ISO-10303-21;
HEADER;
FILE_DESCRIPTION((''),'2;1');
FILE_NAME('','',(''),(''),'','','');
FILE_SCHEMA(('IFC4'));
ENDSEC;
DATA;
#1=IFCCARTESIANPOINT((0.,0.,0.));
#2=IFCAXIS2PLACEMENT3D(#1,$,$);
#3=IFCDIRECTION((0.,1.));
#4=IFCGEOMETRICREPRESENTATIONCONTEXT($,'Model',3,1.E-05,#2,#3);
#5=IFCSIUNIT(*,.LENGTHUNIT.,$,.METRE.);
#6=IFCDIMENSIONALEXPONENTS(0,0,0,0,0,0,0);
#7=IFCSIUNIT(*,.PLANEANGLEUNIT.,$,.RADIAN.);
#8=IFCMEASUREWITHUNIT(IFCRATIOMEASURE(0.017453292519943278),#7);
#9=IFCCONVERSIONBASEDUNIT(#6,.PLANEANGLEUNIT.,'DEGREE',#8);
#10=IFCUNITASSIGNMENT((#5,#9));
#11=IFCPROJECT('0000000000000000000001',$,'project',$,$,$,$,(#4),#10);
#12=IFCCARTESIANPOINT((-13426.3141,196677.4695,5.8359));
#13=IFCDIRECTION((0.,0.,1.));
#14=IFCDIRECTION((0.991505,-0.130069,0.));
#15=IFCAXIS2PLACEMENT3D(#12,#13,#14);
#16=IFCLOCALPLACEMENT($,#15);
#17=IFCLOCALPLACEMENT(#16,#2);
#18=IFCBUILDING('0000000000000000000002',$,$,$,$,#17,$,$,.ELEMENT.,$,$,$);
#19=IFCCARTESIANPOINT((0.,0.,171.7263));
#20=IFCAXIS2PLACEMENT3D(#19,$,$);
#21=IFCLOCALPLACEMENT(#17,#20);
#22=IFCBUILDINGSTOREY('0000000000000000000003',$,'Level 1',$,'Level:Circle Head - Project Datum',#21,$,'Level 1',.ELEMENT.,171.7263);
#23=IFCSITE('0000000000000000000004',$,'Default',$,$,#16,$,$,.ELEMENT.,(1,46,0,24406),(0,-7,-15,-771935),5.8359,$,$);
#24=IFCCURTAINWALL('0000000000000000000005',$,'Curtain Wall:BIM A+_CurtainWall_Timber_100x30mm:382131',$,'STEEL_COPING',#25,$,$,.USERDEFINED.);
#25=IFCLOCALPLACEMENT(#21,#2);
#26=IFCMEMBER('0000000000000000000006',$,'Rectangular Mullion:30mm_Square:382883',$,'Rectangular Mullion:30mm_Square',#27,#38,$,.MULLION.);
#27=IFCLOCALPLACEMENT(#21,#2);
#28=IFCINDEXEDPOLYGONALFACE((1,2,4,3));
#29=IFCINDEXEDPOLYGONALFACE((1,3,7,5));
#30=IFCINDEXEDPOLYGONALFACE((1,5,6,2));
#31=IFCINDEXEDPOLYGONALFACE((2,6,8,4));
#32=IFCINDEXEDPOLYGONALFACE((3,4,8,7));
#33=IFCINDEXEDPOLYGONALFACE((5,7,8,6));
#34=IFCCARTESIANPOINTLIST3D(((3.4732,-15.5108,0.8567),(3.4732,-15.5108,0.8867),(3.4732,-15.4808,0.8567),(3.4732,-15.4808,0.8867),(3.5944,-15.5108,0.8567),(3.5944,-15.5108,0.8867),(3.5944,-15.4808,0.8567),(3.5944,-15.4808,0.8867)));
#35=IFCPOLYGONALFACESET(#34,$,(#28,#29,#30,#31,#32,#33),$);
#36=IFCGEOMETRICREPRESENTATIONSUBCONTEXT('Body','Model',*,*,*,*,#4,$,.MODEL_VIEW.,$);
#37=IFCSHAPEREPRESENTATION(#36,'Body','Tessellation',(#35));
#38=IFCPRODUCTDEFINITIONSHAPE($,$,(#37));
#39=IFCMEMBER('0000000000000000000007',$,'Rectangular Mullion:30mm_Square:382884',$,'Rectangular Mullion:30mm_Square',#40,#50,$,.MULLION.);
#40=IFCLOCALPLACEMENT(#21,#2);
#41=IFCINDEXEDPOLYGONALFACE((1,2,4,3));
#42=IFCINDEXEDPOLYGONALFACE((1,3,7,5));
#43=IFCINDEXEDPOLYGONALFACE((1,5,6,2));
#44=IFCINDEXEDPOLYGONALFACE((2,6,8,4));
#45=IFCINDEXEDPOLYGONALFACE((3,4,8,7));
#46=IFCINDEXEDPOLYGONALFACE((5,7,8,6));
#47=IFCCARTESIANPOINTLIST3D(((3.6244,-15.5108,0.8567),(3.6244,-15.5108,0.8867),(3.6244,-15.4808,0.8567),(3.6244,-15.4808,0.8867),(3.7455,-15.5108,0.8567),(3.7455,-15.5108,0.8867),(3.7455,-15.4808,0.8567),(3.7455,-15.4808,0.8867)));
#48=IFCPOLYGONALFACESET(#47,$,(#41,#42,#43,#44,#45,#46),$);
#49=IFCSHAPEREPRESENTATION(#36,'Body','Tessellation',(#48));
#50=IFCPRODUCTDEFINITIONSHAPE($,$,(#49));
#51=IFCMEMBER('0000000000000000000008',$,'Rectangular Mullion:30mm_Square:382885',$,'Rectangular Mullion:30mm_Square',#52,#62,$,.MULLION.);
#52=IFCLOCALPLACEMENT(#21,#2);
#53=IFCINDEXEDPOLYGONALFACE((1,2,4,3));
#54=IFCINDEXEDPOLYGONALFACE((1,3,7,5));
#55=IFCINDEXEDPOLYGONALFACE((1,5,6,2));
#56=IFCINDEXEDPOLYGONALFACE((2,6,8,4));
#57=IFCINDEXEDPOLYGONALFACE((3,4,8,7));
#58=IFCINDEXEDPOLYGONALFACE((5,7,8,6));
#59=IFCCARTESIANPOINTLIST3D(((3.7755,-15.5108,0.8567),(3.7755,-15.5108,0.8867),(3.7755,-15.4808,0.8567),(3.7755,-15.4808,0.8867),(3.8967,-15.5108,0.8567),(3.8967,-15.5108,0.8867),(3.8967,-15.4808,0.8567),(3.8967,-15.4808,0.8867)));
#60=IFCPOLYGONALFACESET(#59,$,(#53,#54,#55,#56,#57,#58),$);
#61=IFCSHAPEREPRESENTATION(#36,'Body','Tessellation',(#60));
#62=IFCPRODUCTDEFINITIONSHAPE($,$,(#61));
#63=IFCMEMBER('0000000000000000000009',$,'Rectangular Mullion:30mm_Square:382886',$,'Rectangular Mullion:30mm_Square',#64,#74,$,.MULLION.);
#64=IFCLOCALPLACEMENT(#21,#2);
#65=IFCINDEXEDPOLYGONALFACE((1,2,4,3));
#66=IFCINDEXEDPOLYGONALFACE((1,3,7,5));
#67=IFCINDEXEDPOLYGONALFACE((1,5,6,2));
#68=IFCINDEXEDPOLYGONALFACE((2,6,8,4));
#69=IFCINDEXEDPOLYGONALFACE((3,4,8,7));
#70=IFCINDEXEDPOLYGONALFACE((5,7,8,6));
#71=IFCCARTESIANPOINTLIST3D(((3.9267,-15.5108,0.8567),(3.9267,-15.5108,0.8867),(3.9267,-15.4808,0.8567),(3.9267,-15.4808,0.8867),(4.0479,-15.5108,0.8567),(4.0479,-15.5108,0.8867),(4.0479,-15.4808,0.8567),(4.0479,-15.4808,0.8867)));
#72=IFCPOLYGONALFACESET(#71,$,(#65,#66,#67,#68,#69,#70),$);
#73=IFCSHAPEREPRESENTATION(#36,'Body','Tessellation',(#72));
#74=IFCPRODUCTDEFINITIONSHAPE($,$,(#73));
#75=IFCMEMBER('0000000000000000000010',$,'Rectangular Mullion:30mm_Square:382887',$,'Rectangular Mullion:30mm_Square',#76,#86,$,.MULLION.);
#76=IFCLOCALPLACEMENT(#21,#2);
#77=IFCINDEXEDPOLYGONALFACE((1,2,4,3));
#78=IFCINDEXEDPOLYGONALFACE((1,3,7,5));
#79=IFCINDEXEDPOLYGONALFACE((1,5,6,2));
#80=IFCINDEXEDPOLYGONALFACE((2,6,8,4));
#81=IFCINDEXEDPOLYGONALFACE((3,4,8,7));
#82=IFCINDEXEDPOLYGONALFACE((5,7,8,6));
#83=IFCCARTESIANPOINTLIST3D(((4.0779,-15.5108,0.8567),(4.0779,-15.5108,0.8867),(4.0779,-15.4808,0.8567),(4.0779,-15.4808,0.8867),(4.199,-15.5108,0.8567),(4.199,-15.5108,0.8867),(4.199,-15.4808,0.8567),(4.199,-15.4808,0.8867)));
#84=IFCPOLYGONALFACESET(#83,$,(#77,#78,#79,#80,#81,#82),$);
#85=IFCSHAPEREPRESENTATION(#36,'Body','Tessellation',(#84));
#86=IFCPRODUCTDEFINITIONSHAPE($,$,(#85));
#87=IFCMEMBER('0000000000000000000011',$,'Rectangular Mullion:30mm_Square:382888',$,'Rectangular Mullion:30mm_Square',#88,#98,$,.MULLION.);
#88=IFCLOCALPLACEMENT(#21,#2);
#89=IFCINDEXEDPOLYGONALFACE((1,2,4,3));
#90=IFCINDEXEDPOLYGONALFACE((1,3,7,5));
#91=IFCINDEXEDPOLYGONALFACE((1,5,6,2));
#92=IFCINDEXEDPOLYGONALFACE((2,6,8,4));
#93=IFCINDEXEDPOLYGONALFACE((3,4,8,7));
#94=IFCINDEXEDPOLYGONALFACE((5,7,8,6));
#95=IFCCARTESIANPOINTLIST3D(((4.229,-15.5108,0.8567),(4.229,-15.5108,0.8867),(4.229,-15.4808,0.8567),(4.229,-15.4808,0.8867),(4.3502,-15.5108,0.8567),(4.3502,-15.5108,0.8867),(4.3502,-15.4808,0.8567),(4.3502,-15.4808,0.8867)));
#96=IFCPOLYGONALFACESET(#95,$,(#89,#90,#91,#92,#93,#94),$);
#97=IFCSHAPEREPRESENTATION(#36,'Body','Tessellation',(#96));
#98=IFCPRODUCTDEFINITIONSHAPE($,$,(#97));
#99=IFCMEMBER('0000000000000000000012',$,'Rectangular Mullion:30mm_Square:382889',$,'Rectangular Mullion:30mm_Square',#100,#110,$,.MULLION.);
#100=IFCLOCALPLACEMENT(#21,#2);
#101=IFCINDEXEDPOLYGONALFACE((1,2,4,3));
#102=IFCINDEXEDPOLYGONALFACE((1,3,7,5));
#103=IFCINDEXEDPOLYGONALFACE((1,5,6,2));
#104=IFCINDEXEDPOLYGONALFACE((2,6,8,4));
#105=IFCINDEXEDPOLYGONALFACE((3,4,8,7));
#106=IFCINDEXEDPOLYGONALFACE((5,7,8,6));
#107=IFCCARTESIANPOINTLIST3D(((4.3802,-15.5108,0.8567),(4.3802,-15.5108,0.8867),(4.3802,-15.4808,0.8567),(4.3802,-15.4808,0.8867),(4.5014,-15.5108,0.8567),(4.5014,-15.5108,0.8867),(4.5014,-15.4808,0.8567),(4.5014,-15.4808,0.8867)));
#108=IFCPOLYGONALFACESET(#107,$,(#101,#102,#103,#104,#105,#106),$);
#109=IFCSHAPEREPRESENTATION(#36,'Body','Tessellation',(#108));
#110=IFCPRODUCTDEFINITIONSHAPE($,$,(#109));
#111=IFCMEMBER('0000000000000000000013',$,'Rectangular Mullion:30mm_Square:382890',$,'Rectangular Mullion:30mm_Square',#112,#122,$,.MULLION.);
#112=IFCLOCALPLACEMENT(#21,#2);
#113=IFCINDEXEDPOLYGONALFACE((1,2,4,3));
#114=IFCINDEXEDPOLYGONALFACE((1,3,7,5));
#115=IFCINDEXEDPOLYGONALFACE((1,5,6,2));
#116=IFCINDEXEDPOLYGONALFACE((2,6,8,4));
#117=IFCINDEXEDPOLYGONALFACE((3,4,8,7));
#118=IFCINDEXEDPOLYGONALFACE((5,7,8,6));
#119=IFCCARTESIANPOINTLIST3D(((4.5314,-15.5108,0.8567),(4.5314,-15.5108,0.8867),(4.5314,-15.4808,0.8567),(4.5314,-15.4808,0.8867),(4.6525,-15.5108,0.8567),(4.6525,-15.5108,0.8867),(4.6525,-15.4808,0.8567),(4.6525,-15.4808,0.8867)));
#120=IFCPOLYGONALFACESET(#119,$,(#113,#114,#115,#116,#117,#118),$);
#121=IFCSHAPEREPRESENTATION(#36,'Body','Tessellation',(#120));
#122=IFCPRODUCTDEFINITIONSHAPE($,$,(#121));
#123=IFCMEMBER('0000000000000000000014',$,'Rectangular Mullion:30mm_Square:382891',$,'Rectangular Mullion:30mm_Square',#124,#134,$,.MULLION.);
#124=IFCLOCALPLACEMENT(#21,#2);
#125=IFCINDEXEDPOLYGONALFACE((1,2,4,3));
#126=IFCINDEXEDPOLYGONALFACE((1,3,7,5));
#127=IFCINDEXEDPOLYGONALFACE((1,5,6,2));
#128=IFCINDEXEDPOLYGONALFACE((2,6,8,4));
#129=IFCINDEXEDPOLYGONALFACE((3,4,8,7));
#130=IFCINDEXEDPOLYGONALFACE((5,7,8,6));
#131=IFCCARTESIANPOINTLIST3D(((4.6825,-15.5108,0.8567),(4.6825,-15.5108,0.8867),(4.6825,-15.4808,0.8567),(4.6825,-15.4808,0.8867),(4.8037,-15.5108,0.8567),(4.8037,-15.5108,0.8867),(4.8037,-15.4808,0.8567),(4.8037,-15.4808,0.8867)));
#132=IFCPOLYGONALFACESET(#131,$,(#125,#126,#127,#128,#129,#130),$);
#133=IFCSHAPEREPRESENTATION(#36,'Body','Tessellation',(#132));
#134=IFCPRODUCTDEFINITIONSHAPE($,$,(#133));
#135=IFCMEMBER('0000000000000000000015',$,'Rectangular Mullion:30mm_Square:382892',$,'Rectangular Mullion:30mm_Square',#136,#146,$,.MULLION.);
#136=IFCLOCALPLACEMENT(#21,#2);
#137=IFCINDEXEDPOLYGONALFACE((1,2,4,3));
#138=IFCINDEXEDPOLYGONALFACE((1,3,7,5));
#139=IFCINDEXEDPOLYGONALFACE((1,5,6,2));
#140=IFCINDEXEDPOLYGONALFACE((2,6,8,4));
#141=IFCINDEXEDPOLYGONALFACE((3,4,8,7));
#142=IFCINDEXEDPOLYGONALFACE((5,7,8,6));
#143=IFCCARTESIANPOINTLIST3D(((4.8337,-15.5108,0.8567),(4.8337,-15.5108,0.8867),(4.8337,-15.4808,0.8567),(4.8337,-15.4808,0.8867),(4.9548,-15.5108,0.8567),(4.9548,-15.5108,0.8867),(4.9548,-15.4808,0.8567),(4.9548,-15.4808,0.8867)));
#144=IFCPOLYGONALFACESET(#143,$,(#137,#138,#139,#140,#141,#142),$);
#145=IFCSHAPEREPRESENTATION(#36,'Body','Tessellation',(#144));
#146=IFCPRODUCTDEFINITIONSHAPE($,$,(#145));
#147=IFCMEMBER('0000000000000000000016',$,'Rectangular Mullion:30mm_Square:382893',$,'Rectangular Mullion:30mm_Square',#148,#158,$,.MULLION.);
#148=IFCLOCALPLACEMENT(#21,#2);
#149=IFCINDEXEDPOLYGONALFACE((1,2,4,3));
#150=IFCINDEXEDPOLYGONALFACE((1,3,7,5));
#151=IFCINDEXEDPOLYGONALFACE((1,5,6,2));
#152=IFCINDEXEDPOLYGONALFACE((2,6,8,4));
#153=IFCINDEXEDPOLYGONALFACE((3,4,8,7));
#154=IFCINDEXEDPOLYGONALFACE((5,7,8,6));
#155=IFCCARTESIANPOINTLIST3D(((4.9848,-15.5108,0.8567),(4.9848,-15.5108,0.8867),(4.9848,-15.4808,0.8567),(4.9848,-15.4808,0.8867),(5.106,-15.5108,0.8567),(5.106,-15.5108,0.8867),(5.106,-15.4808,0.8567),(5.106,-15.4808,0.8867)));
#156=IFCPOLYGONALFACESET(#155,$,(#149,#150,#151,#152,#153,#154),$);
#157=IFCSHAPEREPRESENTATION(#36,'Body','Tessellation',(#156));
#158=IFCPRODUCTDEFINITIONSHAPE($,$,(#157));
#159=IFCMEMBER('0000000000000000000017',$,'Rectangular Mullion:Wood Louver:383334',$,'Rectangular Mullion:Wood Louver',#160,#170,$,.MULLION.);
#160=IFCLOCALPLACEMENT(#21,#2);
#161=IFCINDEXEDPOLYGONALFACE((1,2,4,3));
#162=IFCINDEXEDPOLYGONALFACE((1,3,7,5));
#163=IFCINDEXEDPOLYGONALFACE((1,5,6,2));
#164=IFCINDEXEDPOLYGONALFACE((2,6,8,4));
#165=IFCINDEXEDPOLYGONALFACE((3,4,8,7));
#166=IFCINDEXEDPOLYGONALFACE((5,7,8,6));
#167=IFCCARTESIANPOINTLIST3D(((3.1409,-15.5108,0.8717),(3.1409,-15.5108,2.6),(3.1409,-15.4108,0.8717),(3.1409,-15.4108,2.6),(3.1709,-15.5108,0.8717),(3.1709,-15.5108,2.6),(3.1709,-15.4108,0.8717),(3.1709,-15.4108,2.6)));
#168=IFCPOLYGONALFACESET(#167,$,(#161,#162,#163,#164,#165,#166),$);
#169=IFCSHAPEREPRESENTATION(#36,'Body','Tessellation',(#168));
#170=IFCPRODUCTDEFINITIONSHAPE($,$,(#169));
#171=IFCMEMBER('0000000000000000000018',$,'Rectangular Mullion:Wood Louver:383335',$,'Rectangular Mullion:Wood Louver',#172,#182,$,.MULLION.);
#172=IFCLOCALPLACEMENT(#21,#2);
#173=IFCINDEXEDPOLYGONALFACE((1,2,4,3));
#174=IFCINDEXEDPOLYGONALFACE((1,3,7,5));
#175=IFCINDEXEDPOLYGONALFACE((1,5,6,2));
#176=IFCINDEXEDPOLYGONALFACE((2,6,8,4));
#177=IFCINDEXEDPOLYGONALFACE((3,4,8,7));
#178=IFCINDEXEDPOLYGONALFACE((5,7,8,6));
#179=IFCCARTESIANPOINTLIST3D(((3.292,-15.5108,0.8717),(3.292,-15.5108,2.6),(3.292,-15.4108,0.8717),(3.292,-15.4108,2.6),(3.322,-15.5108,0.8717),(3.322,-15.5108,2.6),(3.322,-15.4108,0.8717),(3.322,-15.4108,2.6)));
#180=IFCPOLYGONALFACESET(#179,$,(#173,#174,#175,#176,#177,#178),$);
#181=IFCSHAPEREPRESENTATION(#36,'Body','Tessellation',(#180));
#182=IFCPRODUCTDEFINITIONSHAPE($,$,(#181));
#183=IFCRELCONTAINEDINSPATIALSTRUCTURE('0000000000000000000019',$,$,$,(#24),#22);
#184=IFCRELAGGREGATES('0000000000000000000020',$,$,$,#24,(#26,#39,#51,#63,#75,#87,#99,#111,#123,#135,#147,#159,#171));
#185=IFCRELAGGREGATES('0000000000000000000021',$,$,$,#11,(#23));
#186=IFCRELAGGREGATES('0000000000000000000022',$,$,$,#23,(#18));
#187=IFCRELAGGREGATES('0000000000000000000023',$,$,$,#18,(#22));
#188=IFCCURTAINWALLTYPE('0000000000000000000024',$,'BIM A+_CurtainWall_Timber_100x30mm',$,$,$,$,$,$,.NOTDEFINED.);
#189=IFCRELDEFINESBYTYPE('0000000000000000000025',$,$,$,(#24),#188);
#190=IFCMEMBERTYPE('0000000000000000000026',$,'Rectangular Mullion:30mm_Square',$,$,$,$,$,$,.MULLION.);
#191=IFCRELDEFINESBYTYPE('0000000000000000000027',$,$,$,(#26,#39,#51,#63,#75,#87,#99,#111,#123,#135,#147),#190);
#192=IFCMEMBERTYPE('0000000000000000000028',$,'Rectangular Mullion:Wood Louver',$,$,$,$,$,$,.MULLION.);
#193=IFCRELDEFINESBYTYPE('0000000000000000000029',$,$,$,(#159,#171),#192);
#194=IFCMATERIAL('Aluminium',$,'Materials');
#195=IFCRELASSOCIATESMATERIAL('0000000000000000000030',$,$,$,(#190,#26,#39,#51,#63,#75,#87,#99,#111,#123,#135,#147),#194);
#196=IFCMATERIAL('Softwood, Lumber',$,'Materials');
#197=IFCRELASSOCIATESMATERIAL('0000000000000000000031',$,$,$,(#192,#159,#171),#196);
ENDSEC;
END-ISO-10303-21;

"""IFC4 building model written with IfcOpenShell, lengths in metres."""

from ifc_helpers import new_model, entity, si_unit, converted_unit, direction, frame, origin, place, context, subcontext, project, spatial, indexed_curve, outline, extrude, source, transform, mapped, material, type_object, type_shapes, element, aggregate, save


model = new_model("IFC4")

# Units and contexts
model_context = context("Model", 3, precision=1e-05, world=origin(), true_north=direction((0.0, 1.0)))
body_context = subcontext(model_context, "Body", "Model", "MODEL_VIEW")
ifc_project = project(units=[si_unit("LENGTHUNIT", "METRE"), converted_unit("PLANEANGLEUNIT", "DEGREE", entity("IfcRatioMeasure", 0.017453292519943278), si_unit("PLANEANGLEUNIT", "RADIAN"), dimensions=[0, 0, 0, 0, 0, 0, 0])], contexts=[model_context])

# Site, building, storey
site_placement = place(None, frame((-13426.3141, 196677.4695, 5.8359), z_axis=(0.0, 0.0, 1.0), x_axis=(0.991505, -0.130069, 0.0)))
site = spatial("IfcSite", under=ifc_project, at=site_placement, Name="Default", CompositionType="ELEMENT", RefLatitude=(1, 46, 0, 24406), RefLongitude=(0, -7, -15, -771935), RefElevation=5.8359)
building_placement = place(site_placement, origin())
building = spatial("IfcBuilding", under=site, at=building_placement, CompositionType="ELEMENT")
storey_placement = place(building_placement, frame((0.0, 0.0, 171.7263)))
storey = spatial("IfcBuildingStorey", under=building, at=storey_placement, Name="Level 1", ObjectType="Level:Circle Head - Project Datum", LongName="Level 1", CompositionType="ELEMENT", Elevation=171.7263)

# Curtain wall, members
ifc_material_1 = material(Name="Aluminium", Category="Materials")
curtain_wall_type_1 = type_object("IfcCurtainWallType", Name="BIM A+_CurtainWall_Timber_100x30mm", PredefinedType="NOTDEFINED")
curtain_wall_1_placement = place(storey_placement, frame((0.0, 0.0, -171.7263)))
curtain_wall_1 = element("IfcCurtainWall", 1, at=curtain_wall_1_placement, inside=storey, type_object=curtain_wall_type_1, Name="Curtain Wall:BIM A+_CurtainWall_Timber_100x30mm:382131", ObjectType="STEEL_COPING", PredefinedType="USERDEFINED")
member_type_1 = type_object("IfcMemberType", Name="Rectangular Mullion:30mm_Square", PredefinedType="MULLION", material=ifc_material_1)
shared_shape_1 = source(origin(), body_context, "Body", "SweptSolid", [
    extrude(outline(indexed_curve([(-0.015, -0.015), (0.015, -0.015), (0.015, 0.015), (-0.015, 0.015), (-0.015, -0.015)], self_intersect=False)), frame((0.0, 0.0, -0.1212), z_axis=(0.0, 0.0, 1.0), x_axis=(0.0, -1.0, 0.0)), (0.0, 0.0, 1.0), 0.1212),
])
type_shapes(member_type_1, [shared_shape_1])
member_1_placement = place(curtain_wall_1_placement, frame((3.5944, -15.4958, 172.598), z_axis=(1.0, 0.0, 0.0), x_axis=(0.0, 0.0, 1.0)))
member_1 = element("IfcMember", 2, at=member_1_placement, type_object=member_type_1, material=ifc_material_1, Name="Rectangular Mullion:30mm_Square:382883", ObjectType="Rectangular Mullion:30mm_Square", PredefinedType="MULLION", context=body_context, shape_type="MappedRepresentation", body=[
    mapped(shared_shape_1, transform((0.0, 0.0, 0.0), scale=1.0)),
])
member_2_placement = place(curtain_wall_1_placement, frame((3.7455, -15.4958, 172.598), z_axis=(1.0, 0.0, 0.0), x_axis=(0.0, 0.0, 1.0)))
member_2 = element("IfcMember", 3, at=member_2_placement, type_object=member_type_1, material=ifc_material_1, Name="Rectangular Mullion:30mm_Square:382884", ObjectType="Rectangular Mullion:30mm_Square", PredefinedType="MULLION", context=body_context, shape_type="MappedRepresentation", body=[
    mapped(shared_shape_1, transform((0.0, 0.0, 0.0), scale=1.0)),
])
member_3_placement = place(curtain_wall_1_placement, frame((3.8967, -15.4958, 172.598), z_axis=(1.0, 0.0, 0.0), x_axis=(0.0, 0.0, 1.0)))
member_3 = element("IfcMember", 4, at=member_3_placement, type_object=member_type_1, material=ifc_material_1, Name="Rectangular Mullion:30mm_Square:382885", ObjectType="Rectangular Mullion:30mm_Square", PredefinedType="MULLION", context=body_context, shape_type="MappedRepresentation", body=[
    mapped(shared_shape_1, transform((0.0, 0.0, 0.0), scale=1.0)),
])
member_4_placement = place(curtain_wall_1_placement, frame((4.0479, -15.4958, 172.598), z_axis=(1.0, 0.0, 0.0), x_axis=(0.0, 0.0, 1.0)))
member_4 = element("IfcMember", 5, at=member_4_placement, type_object=member_type_1, material=ifc_material_1, Name="Rectangular Mullion:30mm_Square:382886", ObjectType="Rectangular Mullion:30mm_Square", PredefinedType="MULLION", context=body_context, shape_type="MappedRepresentation", body=[
    mapped(shared_shape_1, transform((0.0, 0.0, 0.0), scale=1.0)),
])
member_5_placement = place(curtain_wall_1_placement, frame((4.199, -15.4958, 172.598), z_axis=(1.0, 0.0, 0.0), x_axis=(0.0, 0.0, 1.0)))
member_5 = element("IfcMember", 6, at=member_5_placement, type_object=member_type_1, material=ifc_material_1, Name="Rectangular Mullion:30mm_Square:382887", ObjectType="Rectangular Mullion:30mm_Square", PredefinedType="MULLION", context=body_context, shape_type="MappedRepresentation", body=[
    mapped(shared_shape_1, transform((0.0, 0.0, 0.0), scale=1.0)),
])
member_6_placement = place(curtain_wall_1_placement, frame((4.3502, -15.4958, 172.598), z_axis=(1.0, 0.0, 0.0), x_axis=(0.0, 0.0, 1.0)))
member_6 = element("IfcMember", 7, at=member_6_placement, type_object=member_type_1, material=ifc_material_1, Name="Rectangular Mullion:30mm_Square:382888", ObjectType="Rectangular Mullion:30mm_Square", PredefinedType="MULLION", context=body_context, shape_type="MappedRepresentation", body=[
    mapped(shared_shape_1, transform((0.0, 0.0, 0.0), scale=1.0)),
])
member_7_placement = place(curtain_wall_1_placement, frame((4.5014, -15.4958, 172.598), z_axis=(1.0, 0.0, 0.0), x_axis=(0.0, 0.0, 1.0)))
member_7 = element("IfcMember", 8, at=member_7_placement, type_object=member_type_1, material=ifc_material_1, Name="Rectangular Mullion:30mm_Square:382889", ObjectType="Rectangular Mullion:30mm_Square", PredefinedType="MULLION", context=body_context, shape_type="MappedRepresentation", body=[
    mapped(shared_shape_1, transform((0.0, 0.0, 0.0), scale=1.0)),
])
member_8_placement = place(curtain_wall_1_placement, frame((4.6525, -15.4958, 172.598), z_axis=(1.0, 0.0, 0.0), x_axis=(0.0, 0.0, 1.0)))
member_8 = element("IfcMember", 9, at=member_8_placement, type_object=member_type_1, material=ifc_material_1, Name="Rectangular Mullion:30mm_Square:382890", ObjectType="Rectangular Mullion:30mm_Square", PredefinedType="MULLION", context=body_context, shape_type="MappedRepresentation", body=[
    mapped(shared_shape_1, transform((0.0, 0.0, 0.0), scale=1.0)),
])
member_9_placement = place(curtain_wall_1_placement, frame((4.8037, -15.4958, 172.598), z_axis=(1.0, 0.0, 0.0), x_axis=(0.0, 0.0, 1.0)))
member_9 = element("IfcMember", 10, at=member_9_placement, type_object=member_type_1, material=ifc_material_1, Name="Rectangular Mullion:30mm_Square:382891", ObjectType="Rectangular Mullion:30mm_Square", PredefinedType="MULLION", context=body_context, shape_type="MappedRepresentation", body=[
    mapped(shared_shape_1, transform((0.0, 0.0, 0.0), scale=1.0)),
])
member_10_placement = place(curtain_wall_1_placement, frame((4.9548, -15.4958, 172.598), z_axis=(1.0, 0.0, 0.0), x_axis=(0.0, 0.0, 1.0)))
member_10 = element("IfcMember", 11, at=member_10_placement, type_object=member_type_1, material=ifc_material_1, Name="Rectangular Mullion:30mm_Square:382892", ObjectType="Rectangular Mullion:30mm_Square", PredefinedType="MULLION", context=body_context, shape_type="MappedRepresentation", body=[
    mapped(shared_shape_1, transform((0.0, 0.0, 0.0), scale=1.0)),
])
member_11_placement = place(curtain_wall_1_placement, frame((5.106, -15.4958, 172.598), z_axis=(1.0, 0.0, 0.0), x_axis=(0.0, 0.0, 1.0)))
member_11 = element("IfcMember", 12, at=member_11_placement, type_object=member_type_1, material=ifc_material_1, Name="Rectangular Mullion:30mm_Square:382893", ObjectType="Rectangular Mullion:30mm_Square", PredefinedType="MULLION", context=body_context, shape_type="MappedRepresentation", body=[
    mapped(shared_shape_1, transform((0.0, 0.0, 0.0), scale=1.0)),
])
ifc_material_2 = material(Name="Softwood, Lumber", Category="Materials")
member_type_2 = type_object("IfcMemberType", Name="Rectangular Mullion:Wood Louver", PredefinedType="MULLION", material=ifc_material_2)
shared_shape_2 = source(origin(), body_context, "Body", "SweptSolid", [
    extrude(outline(indexed_curve([(-0.05, -0.015), (0.05, -0.015), (0.05, 0.015), (-0.05, 0.015), (-0.05, -0.015)], self_intersect=False)), frame((0.0, -0.035, -1.7283), z_axis=(0.0, 0.0, 1.0), x_axis=(0.0, -1.0, 0.0)), (0.0, 0.0, 1.0), 1.7283),
])
type_shapes(member_type_2, [shared_shape_2])
member_12_placement = place(curtain_wall_1_placement, frame((3.1559, -15.4958, 172.598), z_axis=(0.0, 0.0, -1.0), x_axis=(1.0, 0.0, 0.0)))
member_12 = element("IfcMember", 13, at=member_12_placement, type_object=member_type_2, material=ifc_material_2, Name="Rectangular Mullion:Wood Louver:383334", ObjectType="Rectangular Mullion:Wood Louver", PredefinedType="MULLION", context=body_context, shape_type="MappedRepresentation", body=[
    mapped(shared_shape_2, transform((0.0, 0.0, 0.0), scale=1.0)),
])
member_13_placement = place(curtain_wall_1_placement, frame((3.307, -15.4958, 172.598), z_axis=(0.0, 0.0, -1.0), x_axis=(1.0, 0.0, 0.0)))
member_13 = element("IfcMember", 14, at=member_13_placement, type_object=member_type_2, material=ifc_material_2, Name="Rectangular Mullion:Wood Louver:383335", ObjectType="Rectangular Mullion:Wood Louver", PredefinedType="MULLION", context=body_context, shape_type="MappedRepresentation", body=[
    mapped(shared_shape_2, transform((0.0, 0.0, 0.0), scale=1.0)),
])
aggregate(curtain_wall_1, [member_1, member_2, member_3, member_4, member_5, member_6, member_7, member_8, member_9, member_10, member_11, member_12, member_13])

save(model, "model.ifc")
